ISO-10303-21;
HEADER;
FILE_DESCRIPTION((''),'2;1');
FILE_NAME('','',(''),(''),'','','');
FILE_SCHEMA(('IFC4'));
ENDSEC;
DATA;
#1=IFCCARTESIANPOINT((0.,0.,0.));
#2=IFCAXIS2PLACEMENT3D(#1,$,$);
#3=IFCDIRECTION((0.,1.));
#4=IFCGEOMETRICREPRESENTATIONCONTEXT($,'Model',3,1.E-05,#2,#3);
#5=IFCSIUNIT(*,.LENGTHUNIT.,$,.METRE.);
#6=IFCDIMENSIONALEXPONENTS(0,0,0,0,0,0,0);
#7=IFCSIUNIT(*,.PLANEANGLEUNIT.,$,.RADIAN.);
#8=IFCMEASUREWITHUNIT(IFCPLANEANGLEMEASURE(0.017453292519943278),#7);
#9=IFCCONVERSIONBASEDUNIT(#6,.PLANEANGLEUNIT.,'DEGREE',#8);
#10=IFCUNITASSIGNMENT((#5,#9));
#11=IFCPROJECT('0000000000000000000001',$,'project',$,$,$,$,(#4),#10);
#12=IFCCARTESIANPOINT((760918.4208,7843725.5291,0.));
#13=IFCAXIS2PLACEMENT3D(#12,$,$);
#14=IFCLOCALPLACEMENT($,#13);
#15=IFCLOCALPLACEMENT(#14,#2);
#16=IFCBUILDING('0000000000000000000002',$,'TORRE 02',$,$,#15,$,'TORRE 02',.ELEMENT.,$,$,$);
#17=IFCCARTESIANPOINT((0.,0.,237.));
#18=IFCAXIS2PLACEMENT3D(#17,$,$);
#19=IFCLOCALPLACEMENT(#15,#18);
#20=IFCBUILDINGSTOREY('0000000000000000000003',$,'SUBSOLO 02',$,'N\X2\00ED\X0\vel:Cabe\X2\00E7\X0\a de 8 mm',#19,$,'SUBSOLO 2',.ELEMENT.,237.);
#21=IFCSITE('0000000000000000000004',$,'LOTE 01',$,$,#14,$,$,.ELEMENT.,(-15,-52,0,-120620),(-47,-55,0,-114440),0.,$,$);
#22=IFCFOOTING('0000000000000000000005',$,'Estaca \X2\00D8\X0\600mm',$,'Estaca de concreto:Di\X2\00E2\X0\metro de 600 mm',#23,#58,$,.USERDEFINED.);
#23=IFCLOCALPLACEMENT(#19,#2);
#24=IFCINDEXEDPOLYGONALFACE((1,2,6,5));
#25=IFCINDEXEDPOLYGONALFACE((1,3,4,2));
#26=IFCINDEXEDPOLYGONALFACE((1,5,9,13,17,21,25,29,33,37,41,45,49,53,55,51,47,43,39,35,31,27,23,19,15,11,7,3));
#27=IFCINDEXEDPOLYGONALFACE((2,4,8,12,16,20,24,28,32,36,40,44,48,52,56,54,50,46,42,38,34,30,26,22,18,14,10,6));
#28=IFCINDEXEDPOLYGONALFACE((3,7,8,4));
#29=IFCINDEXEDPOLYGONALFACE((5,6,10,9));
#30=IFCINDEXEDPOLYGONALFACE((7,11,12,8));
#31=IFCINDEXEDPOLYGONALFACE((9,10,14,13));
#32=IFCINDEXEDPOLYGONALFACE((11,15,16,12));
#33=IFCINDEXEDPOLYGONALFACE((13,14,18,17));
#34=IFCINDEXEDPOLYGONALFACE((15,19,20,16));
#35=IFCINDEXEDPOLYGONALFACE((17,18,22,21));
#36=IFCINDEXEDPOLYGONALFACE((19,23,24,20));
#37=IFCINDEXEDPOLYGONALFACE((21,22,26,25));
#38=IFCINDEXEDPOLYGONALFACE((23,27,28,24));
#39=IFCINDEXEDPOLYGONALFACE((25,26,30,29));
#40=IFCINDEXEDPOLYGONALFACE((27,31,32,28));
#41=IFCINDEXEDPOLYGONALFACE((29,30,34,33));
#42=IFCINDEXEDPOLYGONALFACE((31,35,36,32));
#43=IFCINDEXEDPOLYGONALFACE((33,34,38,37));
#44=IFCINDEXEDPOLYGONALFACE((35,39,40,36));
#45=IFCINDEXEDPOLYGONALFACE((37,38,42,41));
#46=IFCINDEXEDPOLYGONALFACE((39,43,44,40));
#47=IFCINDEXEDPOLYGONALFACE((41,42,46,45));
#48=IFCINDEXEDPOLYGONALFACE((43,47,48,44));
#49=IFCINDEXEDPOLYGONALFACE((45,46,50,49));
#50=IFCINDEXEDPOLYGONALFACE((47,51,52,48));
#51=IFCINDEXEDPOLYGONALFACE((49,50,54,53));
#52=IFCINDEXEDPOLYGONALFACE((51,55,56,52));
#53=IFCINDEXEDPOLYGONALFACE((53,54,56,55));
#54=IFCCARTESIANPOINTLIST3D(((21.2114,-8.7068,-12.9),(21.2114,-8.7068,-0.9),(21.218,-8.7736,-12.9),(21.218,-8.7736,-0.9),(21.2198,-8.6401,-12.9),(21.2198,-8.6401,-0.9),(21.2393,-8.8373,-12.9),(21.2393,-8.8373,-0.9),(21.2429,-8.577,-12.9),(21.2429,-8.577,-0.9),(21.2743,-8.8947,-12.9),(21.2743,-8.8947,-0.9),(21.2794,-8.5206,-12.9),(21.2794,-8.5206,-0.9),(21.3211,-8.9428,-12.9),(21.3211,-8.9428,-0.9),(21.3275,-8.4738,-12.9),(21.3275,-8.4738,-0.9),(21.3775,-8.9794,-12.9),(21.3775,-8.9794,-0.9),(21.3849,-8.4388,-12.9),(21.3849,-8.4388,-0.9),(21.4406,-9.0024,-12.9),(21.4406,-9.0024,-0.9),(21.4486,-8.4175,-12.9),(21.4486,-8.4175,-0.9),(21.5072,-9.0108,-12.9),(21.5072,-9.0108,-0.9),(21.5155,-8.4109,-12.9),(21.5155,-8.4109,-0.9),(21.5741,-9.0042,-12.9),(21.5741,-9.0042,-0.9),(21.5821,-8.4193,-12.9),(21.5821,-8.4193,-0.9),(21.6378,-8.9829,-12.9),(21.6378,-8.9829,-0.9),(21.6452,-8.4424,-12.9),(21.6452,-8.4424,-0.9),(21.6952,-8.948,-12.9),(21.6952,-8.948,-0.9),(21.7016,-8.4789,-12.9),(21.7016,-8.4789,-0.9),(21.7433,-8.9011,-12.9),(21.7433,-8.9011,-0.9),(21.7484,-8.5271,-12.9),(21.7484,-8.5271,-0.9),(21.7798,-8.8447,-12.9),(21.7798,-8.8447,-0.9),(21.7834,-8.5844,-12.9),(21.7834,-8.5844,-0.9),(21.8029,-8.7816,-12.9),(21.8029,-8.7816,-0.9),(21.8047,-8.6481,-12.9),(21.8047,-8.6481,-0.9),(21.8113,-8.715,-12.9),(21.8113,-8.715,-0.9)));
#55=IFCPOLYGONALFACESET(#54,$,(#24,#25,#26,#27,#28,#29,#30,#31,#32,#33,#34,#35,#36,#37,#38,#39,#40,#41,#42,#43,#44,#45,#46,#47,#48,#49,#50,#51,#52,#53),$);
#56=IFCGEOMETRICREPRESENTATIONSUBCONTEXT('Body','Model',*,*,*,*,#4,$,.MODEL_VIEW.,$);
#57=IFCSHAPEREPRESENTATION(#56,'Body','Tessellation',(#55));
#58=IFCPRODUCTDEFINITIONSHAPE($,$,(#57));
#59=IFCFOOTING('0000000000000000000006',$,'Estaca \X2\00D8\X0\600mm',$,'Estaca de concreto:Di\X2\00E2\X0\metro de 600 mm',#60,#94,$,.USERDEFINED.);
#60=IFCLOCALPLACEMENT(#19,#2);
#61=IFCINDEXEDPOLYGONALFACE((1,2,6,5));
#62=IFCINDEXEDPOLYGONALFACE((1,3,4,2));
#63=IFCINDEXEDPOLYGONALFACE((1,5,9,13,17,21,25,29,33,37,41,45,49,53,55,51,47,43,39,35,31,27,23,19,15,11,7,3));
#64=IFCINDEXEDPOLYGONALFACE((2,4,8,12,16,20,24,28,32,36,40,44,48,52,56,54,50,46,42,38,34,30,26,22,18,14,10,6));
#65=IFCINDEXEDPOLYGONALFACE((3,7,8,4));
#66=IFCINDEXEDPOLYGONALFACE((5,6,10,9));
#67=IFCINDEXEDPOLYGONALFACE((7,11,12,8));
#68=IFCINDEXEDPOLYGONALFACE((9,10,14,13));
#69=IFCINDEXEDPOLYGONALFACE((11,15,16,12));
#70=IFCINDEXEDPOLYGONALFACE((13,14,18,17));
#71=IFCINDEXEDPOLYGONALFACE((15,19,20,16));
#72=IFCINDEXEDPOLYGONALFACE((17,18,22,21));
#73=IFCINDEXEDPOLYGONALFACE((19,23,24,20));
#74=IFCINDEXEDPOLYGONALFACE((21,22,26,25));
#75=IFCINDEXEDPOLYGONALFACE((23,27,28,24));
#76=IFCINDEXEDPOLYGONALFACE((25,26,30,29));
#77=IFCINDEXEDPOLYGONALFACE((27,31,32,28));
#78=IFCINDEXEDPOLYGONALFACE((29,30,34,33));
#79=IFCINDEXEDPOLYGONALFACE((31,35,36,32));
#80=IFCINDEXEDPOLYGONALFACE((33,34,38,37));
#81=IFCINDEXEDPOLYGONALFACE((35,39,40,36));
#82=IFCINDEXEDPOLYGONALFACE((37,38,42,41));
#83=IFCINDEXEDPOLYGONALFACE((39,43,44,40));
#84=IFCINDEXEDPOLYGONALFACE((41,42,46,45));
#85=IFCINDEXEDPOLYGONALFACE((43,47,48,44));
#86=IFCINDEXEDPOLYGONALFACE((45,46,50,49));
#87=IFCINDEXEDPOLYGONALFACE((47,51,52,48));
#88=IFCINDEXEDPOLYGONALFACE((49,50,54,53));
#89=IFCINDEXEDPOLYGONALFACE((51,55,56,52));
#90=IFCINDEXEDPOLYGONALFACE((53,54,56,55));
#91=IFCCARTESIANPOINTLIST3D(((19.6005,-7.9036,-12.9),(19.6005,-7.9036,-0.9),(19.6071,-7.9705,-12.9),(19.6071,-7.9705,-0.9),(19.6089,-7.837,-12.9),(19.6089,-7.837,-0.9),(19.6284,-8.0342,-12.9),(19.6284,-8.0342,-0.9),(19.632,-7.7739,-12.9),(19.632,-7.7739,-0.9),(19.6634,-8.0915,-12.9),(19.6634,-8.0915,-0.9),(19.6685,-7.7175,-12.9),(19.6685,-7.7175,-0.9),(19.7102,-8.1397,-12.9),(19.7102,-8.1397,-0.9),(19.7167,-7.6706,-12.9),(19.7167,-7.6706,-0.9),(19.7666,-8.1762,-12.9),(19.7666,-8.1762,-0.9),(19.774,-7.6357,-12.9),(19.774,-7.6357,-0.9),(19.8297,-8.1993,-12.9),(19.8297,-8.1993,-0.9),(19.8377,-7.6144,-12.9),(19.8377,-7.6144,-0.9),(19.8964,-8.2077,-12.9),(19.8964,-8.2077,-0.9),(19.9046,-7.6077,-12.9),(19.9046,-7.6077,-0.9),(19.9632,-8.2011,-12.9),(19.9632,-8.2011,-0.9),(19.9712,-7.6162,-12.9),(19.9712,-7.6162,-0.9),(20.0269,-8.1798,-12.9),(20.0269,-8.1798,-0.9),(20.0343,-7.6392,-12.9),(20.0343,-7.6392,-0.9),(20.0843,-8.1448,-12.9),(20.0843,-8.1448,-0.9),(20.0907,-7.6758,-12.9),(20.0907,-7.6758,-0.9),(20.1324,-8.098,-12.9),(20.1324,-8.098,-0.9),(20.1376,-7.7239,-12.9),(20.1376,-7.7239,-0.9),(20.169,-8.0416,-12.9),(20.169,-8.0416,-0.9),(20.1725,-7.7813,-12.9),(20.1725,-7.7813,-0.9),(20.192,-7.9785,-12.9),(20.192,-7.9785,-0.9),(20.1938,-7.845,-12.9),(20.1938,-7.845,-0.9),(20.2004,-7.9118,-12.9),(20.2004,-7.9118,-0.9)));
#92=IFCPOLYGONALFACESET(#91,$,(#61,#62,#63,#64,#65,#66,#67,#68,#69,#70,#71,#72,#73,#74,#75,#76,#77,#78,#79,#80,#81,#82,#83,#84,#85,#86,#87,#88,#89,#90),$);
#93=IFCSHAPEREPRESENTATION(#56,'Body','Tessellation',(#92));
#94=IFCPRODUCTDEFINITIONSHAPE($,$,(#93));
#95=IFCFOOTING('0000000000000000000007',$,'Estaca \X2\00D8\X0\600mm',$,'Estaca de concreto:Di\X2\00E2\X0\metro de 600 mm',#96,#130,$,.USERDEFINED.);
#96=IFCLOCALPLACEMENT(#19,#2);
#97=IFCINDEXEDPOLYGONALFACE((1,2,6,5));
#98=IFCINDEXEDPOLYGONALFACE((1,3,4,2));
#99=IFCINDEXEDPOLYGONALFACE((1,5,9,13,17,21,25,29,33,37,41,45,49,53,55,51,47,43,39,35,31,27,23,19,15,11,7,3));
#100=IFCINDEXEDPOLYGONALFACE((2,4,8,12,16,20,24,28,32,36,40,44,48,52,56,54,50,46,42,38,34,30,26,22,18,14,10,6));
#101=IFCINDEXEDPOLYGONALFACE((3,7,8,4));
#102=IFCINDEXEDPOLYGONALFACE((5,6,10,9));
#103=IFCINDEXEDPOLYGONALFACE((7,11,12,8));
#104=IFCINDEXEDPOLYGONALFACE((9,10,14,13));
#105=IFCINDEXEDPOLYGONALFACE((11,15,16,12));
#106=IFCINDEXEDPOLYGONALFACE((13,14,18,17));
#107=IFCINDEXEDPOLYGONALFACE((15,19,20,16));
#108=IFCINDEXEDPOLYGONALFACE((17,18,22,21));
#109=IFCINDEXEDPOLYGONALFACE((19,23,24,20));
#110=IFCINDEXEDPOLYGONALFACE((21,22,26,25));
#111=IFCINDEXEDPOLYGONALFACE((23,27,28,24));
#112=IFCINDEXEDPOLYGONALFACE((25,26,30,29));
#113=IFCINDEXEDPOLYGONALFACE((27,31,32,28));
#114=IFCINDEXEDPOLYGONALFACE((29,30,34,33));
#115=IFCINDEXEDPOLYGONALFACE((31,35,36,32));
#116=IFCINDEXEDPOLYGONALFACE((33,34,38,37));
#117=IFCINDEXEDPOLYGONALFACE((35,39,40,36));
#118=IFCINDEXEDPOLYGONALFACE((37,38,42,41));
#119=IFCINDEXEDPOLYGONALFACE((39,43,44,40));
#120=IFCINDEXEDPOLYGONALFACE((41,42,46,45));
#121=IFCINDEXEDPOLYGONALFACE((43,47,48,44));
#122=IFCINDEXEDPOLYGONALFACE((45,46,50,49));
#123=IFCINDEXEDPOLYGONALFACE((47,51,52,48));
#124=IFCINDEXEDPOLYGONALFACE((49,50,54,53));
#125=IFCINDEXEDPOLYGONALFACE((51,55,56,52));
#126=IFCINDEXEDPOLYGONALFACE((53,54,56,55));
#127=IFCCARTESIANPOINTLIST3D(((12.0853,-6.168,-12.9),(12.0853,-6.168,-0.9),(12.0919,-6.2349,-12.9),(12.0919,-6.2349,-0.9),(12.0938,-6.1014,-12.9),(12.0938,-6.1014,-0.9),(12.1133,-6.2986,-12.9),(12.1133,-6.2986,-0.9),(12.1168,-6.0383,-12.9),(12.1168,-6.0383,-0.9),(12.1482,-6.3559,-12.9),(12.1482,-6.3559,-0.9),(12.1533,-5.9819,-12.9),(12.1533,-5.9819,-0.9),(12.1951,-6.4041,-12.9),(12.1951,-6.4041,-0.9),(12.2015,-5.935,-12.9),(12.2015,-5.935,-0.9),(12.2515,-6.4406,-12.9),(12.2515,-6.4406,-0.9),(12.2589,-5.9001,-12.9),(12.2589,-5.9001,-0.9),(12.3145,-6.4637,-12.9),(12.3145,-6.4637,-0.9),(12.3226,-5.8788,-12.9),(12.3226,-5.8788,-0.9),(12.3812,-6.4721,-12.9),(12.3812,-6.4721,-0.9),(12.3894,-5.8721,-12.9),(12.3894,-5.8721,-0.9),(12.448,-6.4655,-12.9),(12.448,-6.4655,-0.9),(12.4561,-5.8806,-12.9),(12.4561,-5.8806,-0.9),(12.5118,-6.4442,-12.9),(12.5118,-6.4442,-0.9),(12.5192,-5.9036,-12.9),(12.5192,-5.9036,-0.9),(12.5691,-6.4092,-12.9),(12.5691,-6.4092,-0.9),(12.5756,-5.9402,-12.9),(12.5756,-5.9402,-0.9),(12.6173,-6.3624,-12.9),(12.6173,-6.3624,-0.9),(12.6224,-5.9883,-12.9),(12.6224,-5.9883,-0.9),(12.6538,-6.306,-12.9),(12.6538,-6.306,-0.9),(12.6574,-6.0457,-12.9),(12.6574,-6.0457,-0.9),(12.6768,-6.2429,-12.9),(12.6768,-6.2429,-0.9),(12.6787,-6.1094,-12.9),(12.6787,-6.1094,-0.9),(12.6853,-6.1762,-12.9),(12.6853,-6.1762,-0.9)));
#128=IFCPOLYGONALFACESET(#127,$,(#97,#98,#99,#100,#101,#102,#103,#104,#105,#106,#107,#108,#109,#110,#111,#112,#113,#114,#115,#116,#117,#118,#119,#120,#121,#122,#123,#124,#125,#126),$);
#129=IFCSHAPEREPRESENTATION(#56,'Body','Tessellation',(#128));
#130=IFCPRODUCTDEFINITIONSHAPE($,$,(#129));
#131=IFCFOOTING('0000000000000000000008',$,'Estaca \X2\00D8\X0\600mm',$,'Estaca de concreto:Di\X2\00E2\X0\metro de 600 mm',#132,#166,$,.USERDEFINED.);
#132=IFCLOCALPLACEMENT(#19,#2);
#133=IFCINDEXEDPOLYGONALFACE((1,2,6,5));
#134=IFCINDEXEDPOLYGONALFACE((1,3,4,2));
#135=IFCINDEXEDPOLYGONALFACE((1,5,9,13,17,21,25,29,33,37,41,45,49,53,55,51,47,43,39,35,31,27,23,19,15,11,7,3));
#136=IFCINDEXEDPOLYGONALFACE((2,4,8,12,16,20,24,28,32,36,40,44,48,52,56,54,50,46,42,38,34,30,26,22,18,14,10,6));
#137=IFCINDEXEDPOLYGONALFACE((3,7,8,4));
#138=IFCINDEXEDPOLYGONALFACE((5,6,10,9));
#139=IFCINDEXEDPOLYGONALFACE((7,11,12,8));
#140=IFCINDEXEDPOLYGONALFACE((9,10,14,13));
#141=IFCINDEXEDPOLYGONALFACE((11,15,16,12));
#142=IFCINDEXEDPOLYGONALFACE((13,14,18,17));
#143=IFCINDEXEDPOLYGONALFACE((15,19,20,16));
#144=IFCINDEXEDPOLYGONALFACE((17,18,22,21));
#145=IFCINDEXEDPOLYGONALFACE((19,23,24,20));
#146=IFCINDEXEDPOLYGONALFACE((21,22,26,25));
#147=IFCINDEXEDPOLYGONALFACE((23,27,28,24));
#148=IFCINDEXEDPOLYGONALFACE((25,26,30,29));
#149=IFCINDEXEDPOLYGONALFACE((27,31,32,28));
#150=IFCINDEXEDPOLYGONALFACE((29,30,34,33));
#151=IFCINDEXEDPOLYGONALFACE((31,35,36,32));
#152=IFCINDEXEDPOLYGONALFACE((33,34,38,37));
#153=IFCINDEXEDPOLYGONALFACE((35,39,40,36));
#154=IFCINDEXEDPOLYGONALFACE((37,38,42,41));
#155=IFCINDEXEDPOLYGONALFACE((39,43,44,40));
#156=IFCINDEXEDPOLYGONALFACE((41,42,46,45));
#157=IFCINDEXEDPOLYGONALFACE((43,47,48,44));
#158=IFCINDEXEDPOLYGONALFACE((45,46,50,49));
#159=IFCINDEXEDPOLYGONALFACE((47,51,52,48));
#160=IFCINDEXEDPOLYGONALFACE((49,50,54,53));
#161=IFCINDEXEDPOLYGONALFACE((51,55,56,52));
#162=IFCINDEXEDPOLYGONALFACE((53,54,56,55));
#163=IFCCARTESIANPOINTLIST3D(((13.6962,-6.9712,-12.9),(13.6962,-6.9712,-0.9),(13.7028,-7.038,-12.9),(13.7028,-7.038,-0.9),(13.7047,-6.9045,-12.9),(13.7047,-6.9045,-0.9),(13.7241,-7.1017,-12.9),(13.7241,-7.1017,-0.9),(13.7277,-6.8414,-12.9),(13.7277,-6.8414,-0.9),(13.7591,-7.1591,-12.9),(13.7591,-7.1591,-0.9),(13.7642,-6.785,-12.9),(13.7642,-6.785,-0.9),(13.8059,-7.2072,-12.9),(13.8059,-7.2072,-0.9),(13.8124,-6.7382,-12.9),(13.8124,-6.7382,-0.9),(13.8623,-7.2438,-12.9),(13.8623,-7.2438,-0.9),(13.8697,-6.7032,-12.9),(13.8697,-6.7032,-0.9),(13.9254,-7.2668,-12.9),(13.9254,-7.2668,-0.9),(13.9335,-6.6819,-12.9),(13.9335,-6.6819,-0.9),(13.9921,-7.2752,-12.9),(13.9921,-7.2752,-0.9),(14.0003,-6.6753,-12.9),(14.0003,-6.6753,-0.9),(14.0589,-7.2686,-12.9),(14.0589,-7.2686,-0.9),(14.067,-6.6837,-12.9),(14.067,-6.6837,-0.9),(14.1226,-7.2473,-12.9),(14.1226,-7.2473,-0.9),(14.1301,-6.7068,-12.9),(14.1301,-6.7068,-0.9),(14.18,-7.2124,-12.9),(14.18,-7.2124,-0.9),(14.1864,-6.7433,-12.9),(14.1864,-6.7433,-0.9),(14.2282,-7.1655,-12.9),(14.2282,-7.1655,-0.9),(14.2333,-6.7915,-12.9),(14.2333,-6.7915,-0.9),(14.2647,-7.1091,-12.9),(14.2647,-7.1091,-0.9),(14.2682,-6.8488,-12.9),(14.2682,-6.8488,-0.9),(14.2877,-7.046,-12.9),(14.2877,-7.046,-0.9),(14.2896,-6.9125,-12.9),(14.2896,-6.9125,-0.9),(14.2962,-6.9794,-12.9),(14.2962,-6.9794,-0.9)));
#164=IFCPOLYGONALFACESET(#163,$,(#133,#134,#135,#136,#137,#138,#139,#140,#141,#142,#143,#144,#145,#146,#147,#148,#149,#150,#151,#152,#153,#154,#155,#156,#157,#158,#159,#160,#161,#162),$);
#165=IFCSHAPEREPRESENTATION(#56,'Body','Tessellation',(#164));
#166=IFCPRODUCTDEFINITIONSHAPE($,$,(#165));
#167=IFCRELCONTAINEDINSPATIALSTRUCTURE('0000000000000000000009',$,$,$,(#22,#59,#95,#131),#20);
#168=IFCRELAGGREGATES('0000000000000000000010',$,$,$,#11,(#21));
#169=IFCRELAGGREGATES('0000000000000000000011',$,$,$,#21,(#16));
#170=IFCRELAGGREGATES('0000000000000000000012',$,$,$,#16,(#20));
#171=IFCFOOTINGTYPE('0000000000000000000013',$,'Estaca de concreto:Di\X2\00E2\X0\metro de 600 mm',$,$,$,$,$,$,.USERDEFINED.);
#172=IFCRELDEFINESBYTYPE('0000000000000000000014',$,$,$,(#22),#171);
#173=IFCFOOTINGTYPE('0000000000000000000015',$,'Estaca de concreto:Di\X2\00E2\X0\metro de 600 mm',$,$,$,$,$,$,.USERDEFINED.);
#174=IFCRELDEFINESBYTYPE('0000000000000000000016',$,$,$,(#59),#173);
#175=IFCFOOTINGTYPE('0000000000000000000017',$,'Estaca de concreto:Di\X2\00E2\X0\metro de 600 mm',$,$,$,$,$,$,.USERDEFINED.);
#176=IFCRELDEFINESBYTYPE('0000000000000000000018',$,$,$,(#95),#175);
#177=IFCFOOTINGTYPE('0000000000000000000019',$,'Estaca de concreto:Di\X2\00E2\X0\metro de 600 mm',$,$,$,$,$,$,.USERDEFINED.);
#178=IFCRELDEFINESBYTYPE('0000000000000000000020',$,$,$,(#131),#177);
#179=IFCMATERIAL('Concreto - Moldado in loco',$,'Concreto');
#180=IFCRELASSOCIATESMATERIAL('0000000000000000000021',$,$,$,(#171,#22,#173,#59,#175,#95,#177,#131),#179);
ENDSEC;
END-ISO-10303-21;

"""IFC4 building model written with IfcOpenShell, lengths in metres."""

from ifc_helpers import new_model, entity, si_unit, converted_unit, direction, frame, origin, place, context, subcontext, project, spatial, arc, indexed_curve, outline, extrude, source, transform, mapped, material, type_object, type_shapes, element, save


model = new_model("IFC4")

# Units and contexts
model_context = context("Model", 3, precision=1e-05, world=origin(), true_north=direction((0.0, 1.0)))
body_context = subcontext(model_context, "Body", "Model", "MODEL_VIEW")
ifc_project = project(units=[si_unit("LENGTHUNIT", "METRE"), converted_unit("PLANEANGLEUNIT", "DEGREE", entity("IfcPlaneAngleMeasure", 0.017453292519943278), si_unit("PLANEANGLEUNIT", "RADIAN"), dimensions=[0, 0, 0, 0, 0, 0, 0])], contexts=[model_context])

# Site, building, storey
site_placement = place(None, frame((760918.4208, 7843725.5291, 0.0)))
site = spatial("IfcSite", under=ifc_project, at=site_placement, Name="LOTE 01", CompositionType="ELEMENT", RefLatitude=(-15, -52, 0, -120620), RefLongitude=(-47, -55, 0, -114440), RefElevation=0.0)
building_placement = place(site_placement, origin())
building = spatial("IfcBuilding", under=site, at=building_placement, Name="TORRE 02", LongName="TORRE 02", CompositionType="ELEMENT")
storey_placement = place(building_placement, frame((0.0, 0.0, 237.0)))
storey = spatial("IfcBuildingStorey", under=building, at=storey_placement, Name="SUBSOLO 02", ObjectType="Nível:Cabeça de 8 mm", LongName="SUBSOLO 2", CompositionType="ELEMENT", Elevation=237.0)

# Footings
ifc_material = material(Name="Concreto - Moldado in loco", Category="Concreto")
placement = place(building_placement, frame((0.0, 0.0, 237.0)))
footing_type_1 = type_object("IfcFootingType", Name="Estaca de concreto:Diâmetro de 600 mm", PredefinedType="USERDEFINED", material=ifc_material)
shared_shape_1 = source(origin(), body_context, "Body", "SweptSolid", [
    extrude(outline(indexed_curve([(-0.3, 0.0), (0.0, -0.3), (0.3, 0.0), (0.0, 0.3)], segments=[arc(1, 2, 3), arc(3, 4, 1)], self_intersect=False)), frame((21.5114, -8.7109, -12.0), z_axis=(0.0, 0.0, 1.0), x_axis=(0.894934, -0.446198, 0.0)), (0.0, 0.0, 1.0), 12.0),
])
type_shapes(footing_type_1, [shared_shape_1])
footing_1_placement = place(placement, frame((0.0, 0.0, -0.9)))
element("IfcFooting", 1, at=footing_1_placement, inside=storey, type_object=footing_type_1, material=ifc_material, Name="Estaca Ø600mm", ObjectType="Estaca de concreto:Diâmetro de 600 mm", PredefinedType="USERDEFINED", context=body_context, shape_type="MappedRepresentation", body=[
    mapped(shared_shape_1, transform((0.0, 0.0, 0.0), scale=1.0)),
])
footing_type_2 = type_object("IfcFootingType", Name="Estaca de concreto:Diâmetro de 600 mm", PredefinedType="USERDEFINED", material=ifc_material)
shared_shape_2 = source(origin(), body_context, "Body", "SweptSolid", [
    extrude(outline(indexed_curve([(-0.3, 0.0), (0.0, -0.3), (0.3, 0.0), (0.0, 0.3)], segments=[arc(1, 2, 3), arc(3, 4, 1)], self_intersect=False)), frame((19.9005, -7.9077, -12.0), z_axis=(0.0, 0.0, 1.0), x_axis=(0.894934, -0.446198, 0.0)), (0.0, 0.0, 1.0), 12.0),
])
type_shapes(footing_type_2, [shared_shape_2])
footing_2_placement = place(placement, frame((0.0, 0.0, -0.9)))
element("IfcFooting", 2, at=footing_2_placement, inside=storey, type_object=footing_type_2, material=ifc_material, Name="Estaca Ø600mm", ObjectType="Estaca de concreto:Diâmetro de 600 mm", PredefinedType="USERDEFINED", context=body_context, shape_type="MappedRepresentation", body=[
    mapped(shared_shape_2, transform((0.0, 0.0, 0.0), scale=1.0)),
])
footing_type_3 = type_object("IfcFootingType", Name="Estaca de concreto:Diâmetro de 600 mm", PredefinedType="USERDEFINED", material=ifc_material)
shared_shape_3 = source(origin(), body_context, "Body", "SweptSolid", [
    extrude(outline(indexed_curve([(-0.3, 0.0), (0.0, -0.3), (0.3, 0.0), (0.0, 0.3)], segments=[arc(1, 2, 3), arc(3, 4, 1)], self_intersect=False)), frame((12.3853, -6.1721, -12.0), z_axis=(0.0, 0.0, 1.0), x_axis=(0.894934, -0.446198, 0.0)), (0.0, 0.0, 1.0), 12.0),
])
type_shapes(footing_type_3, [shared_shape_3])
footing_3_placement = place(placement, frame((0.0, 0.0, -0.9)))
element("IfcFooting", 3, at=footing_3_placement, inside=storey, type_object=footing_type_3, material=ifc_material, Name="Estaca Ø600mm", ObjectType="Estaca de concreto:Diâmetro de 600 mm", PredefinedType="USERDEFINED", context=body_context, shape_type="MappedRepresentation", body=[
    mapped(shared_shape_3, transform((0.0, 0.0, 0.0), scale=1.0)),
])
footing_type_4 = type_object("IfcFootingType", Name="Estaca de concreto:Diâmetro de 600 mm", PredefinedType="USERDEFINED", material=ifc_material)
shared_shape_4 = source(origin(), body_context, "Body", "SweptSolid", [
    extrude(outline(indexed_curve([(-0.3, 0.0), (0.0, -0.3), (0.3, 0.0), (0.0, 0.3)], segments=[arc(1, 2, 3), arc(3, 4, 1)], self_intersect=False)), frame((13.9962, -6.9753, -12.0), z_axis=(0.0, 0.0, 1.0), x_axis=(0.894934, -0.446198, 0.0)), (0.0, 0.0, 1.0), 12.0),
])
type_shapes(footing_type_4, [shared_shape_4])
footing_4_placement = place(placement, frame((0.0, 0.0, -0.9)))
element("IfcFooting", 4, at=footing_4_placement, inside=storey, type_object=footing_type_4, material=ifc_material, Name="Estaca Ø600mm", ObjectType="Estaca de concreto:Diâmetro de 600 mm", PredefinedType="USERDEFINED", context=body_context, shape_type="MappedRepresentation", body=[
    mapped(shared_shape_4, transform((0.0, 0.0, 0.0), scale=1.0)),
])

save(model, "model.ifc")
